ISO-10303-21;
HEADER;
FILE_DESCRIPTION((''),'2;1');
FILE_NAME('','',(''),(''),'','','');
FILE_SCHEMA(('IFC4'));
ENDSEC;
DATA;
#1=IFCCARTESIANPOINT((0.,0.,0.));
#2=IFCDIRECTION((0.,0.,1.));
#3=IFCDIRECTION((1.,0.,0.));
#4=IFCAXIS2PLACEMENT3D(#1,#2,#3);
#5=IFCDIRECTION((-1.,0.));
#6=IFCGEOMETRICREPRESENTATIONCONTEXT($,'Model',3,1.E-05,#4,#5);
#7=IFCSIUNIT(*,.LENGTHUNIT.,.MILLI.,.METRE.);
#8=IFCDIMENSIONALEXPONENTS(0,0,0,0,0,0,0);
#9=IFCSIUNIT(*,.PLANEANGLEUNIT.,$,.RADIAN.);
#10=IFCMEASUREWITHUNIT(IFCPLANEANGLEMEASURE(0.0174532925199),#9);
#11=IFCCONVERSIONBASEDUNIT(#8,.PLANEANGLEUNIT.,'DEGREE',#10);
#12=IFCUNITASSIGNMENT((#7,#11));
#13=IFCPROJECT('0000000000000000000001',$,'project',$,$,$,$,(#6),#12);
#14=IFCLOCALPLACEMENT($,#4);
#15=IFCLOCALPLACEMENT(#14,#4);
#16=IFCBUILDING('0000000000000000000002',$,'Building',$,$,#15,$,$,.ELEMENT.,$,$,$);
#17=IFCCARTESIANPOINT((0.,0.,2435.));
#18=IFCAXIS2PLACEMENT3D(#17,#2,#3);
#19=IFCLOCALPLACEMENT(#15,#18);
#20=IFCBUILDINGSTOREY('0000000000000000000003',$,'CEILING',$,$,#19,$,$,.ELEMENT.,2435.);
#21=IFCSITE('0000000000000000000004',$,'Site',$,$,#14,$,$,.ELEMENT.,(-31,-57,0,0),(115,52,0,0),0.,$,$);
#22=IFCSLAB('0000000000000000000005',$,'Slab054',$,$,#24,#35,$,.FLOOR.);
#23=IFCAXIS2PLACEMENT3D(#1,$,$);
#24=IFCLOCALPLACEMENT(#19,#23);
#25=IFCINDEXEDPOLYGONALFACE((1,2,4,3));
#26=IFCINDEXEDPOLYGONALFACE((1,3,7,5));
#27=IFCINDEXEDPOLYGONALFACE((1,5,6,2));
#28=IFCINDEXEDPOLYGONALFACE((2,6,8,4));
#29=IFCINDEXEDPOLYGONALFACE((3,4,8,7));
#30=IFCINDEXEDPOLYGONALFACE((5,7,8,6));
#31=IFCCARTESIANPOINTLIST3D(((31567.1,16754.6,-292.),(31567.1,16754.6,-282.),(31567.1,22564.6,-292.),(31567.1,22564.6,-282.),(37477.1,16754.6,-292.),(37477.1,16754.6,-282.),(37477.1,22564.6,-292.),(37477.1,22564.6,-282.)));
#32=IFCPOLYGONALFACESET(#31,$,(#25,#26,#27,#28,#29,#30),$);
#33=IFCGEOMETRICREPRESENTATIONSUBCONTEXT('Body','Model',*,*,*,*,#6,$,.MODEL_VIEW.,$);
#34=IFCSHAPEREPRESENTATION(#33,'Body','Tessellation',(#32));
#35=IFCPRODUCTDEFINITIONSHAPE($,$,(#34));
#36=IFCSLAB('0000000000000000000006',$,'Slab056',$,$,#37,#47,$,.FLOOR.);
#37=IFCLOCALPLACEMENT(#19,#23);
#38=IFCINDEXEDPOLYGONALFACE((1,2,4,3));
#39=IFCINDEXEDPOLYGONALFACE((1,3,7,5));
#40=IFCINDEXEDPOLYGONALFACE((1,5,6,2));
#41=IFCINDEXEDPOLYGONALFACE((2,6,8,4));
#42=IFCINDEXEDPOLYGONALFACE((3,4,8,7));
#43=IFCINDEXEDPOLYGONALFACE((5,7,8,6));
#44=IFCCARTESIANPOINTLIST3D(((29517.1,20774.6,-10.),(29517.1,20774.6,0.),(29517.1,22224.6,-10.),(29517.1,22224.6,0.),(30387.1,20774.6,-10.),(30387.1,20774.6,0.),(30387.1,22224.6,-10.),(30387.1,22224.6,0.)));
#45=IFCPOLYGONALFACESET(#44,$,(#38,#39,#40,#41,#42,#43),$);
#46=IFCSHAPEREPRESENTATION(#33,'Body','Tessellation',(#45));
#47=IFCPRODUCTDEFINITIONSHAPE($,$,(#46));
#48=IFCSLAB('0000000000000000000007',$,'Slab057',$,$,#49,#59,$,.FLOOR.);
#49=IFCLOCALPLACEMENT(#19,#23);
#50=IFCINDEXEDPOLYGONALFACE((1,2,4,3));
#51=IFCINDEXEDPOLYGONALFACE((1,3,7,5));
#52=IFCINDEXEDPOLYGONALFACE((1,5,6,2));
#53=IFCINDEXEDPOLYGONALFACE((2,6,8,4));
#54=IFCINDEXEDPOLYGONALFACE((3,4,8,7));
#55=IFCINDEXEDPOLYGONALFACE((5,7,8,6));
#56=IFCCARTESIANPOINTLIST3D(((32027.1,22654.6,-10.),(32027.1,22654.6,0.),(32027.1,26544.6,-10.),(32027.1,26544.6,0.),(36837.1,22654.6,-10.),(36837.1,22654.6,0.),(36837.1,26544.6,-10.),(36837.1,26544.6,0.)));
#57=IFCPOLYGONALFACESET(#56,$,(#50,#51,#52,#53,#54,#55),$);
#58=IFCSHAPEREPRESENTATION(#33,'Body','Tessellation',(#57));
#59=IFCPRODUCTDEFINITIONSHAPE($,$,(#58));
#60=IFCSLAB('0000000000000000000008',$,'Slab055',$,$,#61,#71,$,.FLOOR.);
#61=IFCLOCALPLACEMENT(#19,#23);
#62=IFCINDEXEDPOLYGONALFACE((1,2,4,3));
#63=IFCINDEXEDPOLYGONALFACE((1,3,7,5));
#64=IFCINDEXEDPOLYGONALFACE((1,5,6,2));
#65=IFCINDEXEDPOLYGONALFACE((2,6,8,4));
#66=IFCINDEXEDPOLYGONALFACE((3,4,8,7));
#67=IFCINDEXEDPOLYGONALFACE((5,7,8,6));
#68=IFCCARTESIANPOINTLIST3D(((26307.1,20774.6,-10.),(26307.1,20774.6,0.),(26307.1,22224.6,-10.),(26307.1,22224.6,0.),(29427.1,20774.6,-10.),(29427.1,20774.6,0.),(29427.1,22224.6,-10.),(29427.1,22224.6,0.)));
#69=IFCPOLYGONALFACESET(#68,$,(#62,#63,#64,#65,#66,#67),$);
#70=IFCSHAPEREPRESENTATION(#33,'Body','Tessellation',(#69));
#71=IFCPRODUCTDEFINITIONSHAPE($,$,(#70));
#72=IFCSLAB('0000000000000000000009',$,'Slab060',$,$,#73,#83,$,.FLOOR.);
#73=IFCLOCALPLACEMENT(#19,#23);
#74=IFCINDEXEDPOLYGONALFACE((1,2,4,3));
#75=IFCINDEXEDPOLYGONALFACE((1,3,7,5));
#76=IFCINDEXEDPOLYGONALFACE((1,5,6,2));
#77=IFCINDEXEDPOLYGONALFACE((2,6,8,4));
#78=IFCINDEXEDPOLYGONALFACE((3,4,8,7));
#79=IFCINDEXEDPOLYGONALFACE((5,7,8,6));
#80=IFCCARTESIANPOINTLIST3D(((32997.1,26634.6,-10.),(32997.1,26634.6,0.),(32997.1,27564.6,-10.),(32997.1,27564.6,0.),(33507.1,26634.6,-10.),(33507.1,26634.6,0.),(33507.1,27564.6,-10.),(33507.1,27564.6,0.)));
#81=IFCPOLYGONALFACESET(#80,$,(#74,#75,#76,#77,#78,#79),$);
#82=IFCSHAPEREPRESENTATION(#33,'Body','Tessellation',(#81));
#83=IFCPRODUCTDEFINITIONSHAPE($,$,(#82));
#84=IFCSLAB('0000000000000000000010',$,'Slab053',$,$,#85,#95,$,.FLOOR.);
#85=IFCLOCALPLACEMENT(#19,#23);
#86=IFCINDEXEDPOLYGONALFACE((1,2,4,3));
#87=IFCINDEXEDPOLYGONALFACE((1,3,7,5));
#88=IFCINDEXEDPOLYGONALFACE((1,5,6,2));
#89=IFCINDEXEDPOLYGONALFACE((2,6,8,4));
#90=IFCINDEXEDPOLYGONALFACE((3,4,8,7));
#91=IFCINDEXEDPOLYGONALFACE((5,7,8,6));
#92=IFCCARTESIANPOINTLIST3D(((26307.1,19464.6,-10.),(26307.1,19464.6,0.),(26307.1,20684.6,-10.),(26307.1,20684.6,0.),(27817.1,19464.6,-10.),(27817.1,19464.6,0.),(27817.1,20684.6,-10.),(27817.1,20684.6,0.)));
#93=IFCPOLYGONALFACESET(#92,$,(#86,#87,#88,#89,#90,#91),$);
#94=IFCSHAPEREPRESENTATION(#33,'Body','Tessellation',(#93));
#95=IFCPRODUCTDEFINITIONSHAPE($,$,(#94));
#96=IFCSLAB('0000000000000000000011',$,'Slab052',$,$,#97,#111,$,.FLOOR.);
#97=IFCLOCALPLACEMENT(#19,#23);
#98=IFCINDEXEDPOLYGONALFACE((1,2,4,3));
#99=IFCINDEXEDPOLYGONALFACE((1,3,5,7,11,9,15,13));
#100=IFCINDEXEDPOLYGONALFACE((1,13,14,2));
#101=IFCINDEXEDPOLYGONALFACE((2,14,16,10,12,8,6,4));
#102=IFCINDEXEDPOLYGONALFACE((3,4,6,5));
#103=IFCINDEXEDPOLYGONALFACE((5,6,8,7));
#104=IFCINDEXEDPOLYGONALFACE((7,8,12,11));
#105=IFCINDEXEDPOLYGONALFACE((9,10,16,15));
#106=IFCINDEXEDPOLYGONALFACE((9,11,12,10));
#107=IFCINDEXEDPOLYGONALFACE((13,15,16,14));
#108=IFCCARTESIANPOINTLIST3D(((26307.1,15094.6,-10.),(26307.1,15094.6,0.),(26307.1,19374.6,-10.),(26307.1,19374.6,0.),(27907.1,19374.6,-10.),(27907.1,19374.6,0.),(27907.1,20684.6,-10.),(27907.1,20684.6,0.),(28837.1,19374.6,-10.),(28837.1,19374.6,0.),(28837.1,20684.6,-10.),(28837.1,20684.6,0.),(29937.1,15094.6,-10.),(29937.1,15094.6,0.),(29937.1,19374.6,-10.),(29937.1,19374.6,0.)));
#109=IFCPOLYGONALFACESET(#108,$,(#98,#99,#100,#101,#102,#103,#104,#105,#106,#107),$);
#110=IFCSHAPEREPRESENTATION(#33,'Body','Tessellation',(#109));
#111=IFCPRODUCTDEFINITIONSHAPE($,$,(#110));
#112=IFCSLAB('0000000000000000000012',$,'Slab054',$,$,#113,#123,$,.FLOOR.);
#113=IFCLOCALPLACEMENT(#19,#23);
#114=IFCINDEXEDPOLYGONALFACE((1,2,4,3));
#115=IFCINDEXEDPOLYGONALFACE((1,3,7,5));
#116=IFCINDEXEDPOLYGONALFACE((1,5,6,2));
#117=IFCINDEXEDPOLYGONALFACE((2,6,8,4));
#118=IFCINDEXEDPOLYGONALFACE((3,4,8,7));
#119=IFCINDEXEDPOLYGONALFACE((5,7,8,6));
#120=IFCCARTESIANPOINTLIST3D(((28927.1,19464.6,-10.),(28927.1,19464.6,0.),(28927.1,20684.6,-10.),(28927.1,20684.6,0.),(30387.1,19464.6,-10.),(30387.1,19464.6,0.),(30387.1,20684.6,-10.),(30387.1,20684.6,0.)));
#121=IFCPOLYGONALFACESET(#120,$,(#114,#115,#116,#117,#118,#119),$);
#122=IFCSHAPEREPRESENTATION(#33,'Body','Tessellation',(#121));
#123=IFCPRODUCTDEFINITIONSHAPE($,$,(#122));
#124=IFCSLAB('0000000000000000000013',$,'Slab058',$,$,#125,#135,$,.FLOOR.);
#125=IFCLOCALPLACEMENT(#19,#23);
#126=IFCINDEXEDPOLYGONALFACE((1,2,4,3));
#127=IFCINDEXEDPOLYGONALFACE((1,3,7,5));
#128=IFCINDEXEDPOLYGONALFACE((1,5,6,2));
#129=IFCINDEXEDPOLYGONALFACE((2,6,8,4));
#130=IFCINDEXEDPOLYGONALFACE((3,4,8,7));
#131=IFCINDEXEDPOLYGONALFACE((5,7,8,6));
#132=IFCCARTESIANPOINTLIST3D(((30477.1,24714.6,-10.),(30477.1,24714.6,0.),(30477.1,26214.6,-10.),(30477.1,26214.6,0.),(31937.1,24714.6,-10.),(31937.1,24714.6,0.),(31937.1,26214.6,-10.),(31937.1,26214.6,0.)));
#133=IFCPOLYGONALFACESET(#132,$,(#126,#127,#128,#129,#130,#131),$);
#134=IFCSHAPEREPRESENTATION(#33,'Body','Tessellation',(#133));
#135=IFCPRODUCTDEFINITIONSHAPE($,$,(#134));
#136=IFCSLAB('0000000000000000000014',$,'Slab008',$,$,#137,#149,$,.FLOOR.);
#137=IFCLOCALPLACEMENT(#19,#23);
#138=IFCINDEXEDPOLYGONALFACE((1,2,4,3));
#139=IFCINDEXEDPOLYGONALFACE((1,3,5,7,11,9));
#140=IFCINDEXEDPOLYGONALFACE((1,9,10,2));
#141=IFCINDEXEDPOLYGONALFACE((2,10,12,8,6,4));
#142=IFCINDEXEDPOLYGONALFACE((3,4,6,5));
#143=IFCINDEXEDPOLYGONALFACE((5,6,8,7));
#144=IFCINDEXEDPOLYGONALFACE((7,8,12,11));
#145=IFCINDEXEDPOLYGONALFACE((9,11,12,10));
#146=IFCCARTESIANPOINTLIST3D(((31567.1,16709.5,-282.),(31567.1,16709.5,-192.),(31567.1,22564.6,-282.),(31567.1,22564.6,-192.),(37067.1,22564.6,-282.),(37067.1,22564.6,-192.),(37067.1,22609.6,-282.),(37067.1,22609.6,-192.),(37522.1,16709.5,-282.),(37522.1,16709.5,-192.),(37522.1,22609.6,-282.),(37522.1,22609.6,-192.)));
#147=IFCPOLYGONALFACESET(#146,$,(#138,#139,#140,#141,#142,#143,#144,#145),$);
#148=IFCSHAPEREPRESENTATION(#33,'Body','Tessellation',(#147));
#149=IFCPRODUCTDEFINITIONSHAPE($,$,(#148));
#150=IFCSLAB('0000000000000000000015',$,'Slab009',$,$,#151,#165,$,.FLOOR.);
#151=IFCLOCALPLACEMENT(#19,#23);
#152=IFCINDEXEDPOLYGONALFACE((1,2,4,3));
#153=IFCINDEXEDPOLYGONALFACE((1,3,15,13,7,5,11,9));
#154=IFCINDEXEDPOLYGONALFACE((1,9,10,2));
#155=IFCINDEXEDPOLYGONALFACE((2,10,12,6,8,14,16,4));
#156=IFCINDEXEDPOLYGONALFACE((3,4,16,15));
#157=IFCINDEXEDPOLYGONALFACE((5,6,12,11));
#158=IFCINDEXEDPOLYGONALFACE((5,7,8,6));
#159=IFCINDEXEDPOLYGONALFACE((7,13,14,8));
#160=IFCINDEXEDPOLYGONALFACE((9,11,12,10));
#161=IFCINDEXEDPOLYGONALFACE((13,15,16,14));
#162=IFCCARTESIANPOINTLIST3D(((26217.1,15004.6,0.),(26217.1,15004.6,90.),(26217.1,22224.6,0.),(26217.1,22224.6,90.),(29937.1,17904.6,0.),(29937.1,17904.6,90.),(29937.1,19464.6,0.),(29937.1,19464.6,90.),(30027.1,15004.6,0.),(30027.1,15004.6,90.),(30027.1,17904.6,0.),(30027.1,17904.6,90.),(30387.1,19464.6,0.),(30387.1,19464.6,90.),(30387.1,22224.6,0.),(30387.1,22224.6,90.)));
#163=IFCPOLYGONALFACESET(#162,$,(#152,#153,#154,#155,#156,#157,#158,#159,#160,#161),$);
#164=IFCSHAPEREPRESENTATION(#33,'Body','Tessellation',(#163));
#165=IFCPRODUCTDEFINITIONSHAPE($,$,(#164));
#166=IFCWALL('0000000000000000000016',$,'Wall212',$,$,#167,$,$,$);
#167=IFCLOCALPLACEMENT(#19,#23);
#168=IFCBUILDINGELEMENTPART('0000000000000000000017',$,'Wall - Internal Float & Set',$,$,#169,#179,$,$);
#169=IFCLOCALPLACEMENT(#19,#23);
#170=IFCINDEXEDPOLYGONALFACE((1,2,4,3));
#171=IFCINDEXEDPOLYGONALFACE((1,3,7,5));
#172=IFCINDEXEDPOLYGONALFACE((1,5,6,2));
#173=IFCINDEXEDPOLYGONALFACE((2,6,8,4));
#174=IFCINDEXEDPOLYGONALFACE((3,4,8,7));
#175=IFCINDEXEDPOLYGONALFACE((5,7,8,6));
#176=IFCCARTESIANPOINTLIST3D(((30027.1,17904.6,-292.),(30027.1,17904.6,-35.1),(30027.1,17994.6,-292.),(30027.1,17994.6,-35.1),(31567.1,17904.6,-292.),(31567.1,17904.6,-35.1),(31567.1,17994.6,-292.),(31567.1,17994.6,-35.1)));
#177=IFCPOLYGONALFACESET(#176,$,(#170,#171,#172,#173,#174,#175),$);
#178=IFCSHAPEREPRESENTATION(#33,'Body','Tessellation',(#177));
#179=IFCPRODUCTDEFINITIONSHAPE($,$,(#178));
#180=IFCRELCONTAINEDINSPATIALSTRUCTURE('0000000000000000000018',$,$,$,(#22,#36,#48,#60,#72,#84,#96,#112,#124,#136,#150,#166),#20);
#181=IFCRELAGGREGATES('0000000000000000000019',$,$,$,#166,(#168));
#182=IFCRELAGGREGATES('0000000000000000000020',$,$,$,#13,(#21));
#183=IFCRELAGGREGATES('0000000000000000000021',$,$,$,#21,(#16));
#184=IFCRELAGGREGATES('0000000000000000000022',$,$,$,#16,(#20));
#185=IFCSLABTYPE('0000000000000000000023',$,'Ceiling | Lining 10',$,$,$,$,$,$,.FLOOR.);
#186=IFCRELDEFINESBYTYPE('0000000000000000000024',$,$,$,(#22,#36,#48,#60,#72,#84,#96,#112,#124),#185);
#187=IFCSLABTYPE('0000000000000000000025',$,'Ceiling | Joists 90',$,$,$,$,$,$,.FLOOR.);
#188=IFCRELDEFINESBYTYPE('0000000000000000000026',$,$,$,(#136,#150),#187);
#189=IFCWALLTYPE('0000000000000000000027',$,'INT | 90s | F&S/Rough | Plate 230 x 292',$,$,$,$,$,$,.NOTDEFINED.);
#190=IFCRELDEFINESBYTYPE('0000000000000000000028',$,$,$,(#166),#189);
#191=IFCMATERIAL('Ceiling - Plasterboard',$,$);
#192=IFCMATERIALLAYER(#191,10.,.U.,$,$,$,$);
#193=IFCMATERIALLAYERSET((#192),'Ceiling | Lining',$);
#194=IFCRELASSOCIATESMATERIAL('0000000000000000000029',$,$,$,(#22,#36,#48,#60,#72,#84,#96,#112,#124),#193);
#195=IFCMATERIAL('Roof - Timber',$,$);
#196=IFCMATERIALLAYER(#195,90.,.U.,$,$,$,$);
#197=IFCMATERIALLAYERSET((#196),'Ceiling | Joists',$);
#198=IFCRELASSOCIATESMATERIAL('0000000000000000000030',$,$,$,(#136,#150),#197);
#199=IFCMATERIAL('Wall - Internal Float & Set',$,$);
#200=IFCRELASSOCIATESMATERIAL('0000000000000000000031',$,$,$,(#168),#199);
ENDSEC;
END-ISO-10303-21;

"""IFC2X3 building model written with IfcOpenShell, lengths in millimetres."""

from ifc_helpers import new_model, entity, si_unit, converted_unit, direction, frame, origin_with_axes, place, context, subcontext, project, spatial, polyline, outline, extrude, material, layer, layer_set, layer_usage, type_object, element, aggregate, save


model = new_model("IFC2X3")

# Units and contexts
model_context = context("Model", 3, precision=1e-05, world=origin_with_axes(), true_north=direction((-1.0, 0.0)))
body_context = subcontext(model_context, "Body", "Model", "MODEL_VIEW")
ifc_project = project(units=[si_unit("LENGTHUNIT", "METRE", prefix="MILLI"), converted_unit("PLANEANGLEUNIT", "DEGREE", entity("IfcPlaneAngleMeasure", 0.0174532925199), si_unit("PLANEANGLEUNIT", "RADIAN"), dimensions=[0, 0, 0, 0, 0, 0, 0])], contexts=[model_context])

# Site, building, storey
site_placement = place(None, origin_with_axes())
site = spatial("IfcSite", under=ifc_project, at=site_placement, Name="Site", CompositionType="ELEMENT", RefLatitude=(-31, -57, 0, 0), RefLongitude=(115, 52, 0, 0), RefElevation=0.0)
building_placement = place(site_placement, origin_with_axes())
building = spatial("IfcBuilding", under=site, at=building_placement, Name="Building", CompositionType="ELEMENT")
storey_placement = place(building_placement, frame((0.0, 0.0, 2435.0), z_axis=(0.0, 0.0, 1.0), x_axis=(1.0, 0.0, 0.0)))
storey = spatial("IfcBuildingStorey", under=building, at=storey_placement, Name="CEILING", CompositionType="ELEMENT", Elevation=2435.0)

# Slabs
ifc_material_1 = material(Name="Ceiling - Plasterboard")
ifc_layer_1 = layer(ifc_material_1, 10.0, ventilated="UNKNOWN")
ifc_layer_set_1 = layer_set([ifc_layer_1], Name="Ceiling | Lining")
ifc_layer_usage_1 = layer_usage(ifc_layer_set_1, "AXIS3", "NEGATIVE", 10.0)
slab_type_1 = type_object("IfcSlabType", Name="Ceiling | Lining 10", PredefinedType="FLOOR")
slab_1_placement = place(storey_placement, frame((31567.1, 22564.6, -282.0), z_axis=(0.0, 0.0, 1.0), x_axis=(1.0, 0.0, 0.0)))
element("IfcSlab", 1, at=slab_1_placement, inside=storey, type_object=slab_type_1, material=ifc_layer_usage_1, Name="Slab054", PredefinedType="FLOOR", context=body_context, shape_type="SweptSolid", body=[
    extrude(outline(polyline([(0.0, 0.0), (0.0, -5810.0), (5910.0, -5810.0), (5910.0, 0.0), (0.0, 0.0)])), frame((0.0, 0.0, -10.0), z_axis=(0.0, 0.0, 1.0), x_axis=(1.0, 0.0, 0.0)), (0.0, 0.0, 1.0), 10.0),
])
ifc_layer_usage_2 = layer_usage(ifc_layer_set_1, "AXIS3", "NEGATIVE", 10.0)
slab_2_placement = place(storey_placement, frame((29517.1, 22224.6, 0.0), z_axis=(0.0, 0.0, 1.0), x_axis=(1.0, 0.0, 0.0)))
element("IfcSlab", 2, at=slab_2_placement, inside=storey, type_object=slab_type_1, material=ifc_layer_usage_2, Name="Slab056", PredefinedType="FLOOR", context=body_context, shape_type="SweptSolid", body=[
    extrude(outline(polyline([(0.0, 0.0), (0.0, -1450.0), (870.0, -1450.0), (870.0, 0.0), (0.0, 0.0)])), frame((0.0, 0.0, -10.0), z_axis=(0.0, 0.0, 1.0), x_axis=(1.0, 0.0, 0.0)), (0.0, 0.0, 1.0), 10.0),
])
ifc_layer_usage_3 = layer_usage(ifc_layer_set_1, "AXIS3", "NEGATIVE", 10.0)
slab_3_placement = place(storey_placement, frame((32027.1, 22654.6, 0.0), z_axis=(0.0, 0.0, 1.0), x_axis=(1.0, 0.0, 0.0)))
element("IfcSlab", 3, at=slab_3_placement, inside=storey, type_object=slab_type_1, material=ifc_layer_usage_3, Name="Slab057", PredefinedType="FLOOR", context=body_context, shape_type="SweptSolid", body=[
    extrude(outline(polyline([(0.0, 0.0), (4810.0, 0.0), (4810.0, 3890.0), (0.0, 3890.0), (0.0, 0.0)])), frame((0.0, 0.0, -10.0), z_axis=(0.0, 0.0, 1.0), x_axis=(1.0, 0.0, 0.0)), (0.0, 0.0, 1.0), 10.0),
])
ifc_layer_usage_4 = layer_usage(ifc_layer_set_1, "AXIS3", "NEGATIVE", 10.0)
slab_4_placement = place(storey_placement, frame((26307.1, 22224.6, 0.0), z_axis=(0.0, 0.0, 1.0), x_axis=(1.0, 0.0, 0.0)))
element("IfcSlab", 4, at=slab_4_placement, inside=storey, type_object=slab_type_1, material=ifc_layer_usage_4, Name="Slab055", PredefinedType="FLOOR", context=body_context, shape_type="SweptSolid", body=[
    extrude(outline(polyline([(0.0, 0.0), (0.0, -1450.0), (3120.0, -1450.0), (3120.0, 0.0), (0.0, 0.0)])), frame((0.0, 0.0, -10.0), z_axis=(0.0, 0.0, 1.0), x_axis=(1.0, 0.0, 0.0)), (0.0, 0.0, 1.0), 10.0),
])
ifc_layer_usage_5 = layer_usage(ifc_layer_set_1, "AXIS3", "NEGATIVE", 10.0)
slab_5_placement = place(storey_placement, frame((32997.1, 27564.6, 0.0), z_axis=(0.0, 0.0, 1.0), x_axis=(1.0, 0.0, 0.0)))
element("IfcSlab", 5, at=slab_5_placement, inside=storey, type_object=slab_type_1, material=ifc_layer_usage_5, Name="Slab060", PredefinedType="FLOOR", context=body_context, shape_type="SweptSolid", body=[
    extrude(outline(polyline([(0.0, 0.0), (0.0, -930.0), (510.0, -930.0), (510.0, 0.0), (0.0, 0.0)])), frame((0.0, 0.0, -10.0), z_axis=(0.0, 0.0, 1.0), x_axis=(1.0, 0.0, 0.0)), (0.0, 0.0, 1.0), 10.0),
])
ifc_layer_usage_6 = layer_usage(ifc_layer_set_1, "AXIS3", "NEGATIVE", 10.0)
slab_6_placement = place(storey_placement, frame((26307.1, 20684.6, 0.0), z_axis=(0.0, 0.0, 1.0), x_axis=(1.0, 0.0, 0.0)))
element("IfcSlab", 6, at=slab_6_placement, inside=storey, type_object=slab_type_1, material=ifc_layer_usage_6, Name="Slab053", PredefinedType="FLOOR", context=body_context, shape_type="SweptSolid", body=[
    extrude(outline(polyline([(0.0, 0.0), (0.0, -1220.0), (1510.0, -1220.0), (1510.0, 0.0), (0.0, 0.0)])), frame((0.0, 0.0, -10.0), z_axis=(0.0, 0.0, 1.0), x_axis=(1.0, 0.0, 0.0)), (0.0, 0.0, 1.0), 10.0),
])
ifc_layer_usage_7 = layer_usage(ifc_layer_set_1, "AXIS3", "NEGATIVE", 10.0)
slab_7_placement = place(storey_placement, frame((26307.1, 19374.6, 0.0), z_axis=(0.0, 0.0, 1.0), x_axis=(1.0, 0.0, 0.0)))
element("IfcSlab", 7, at=slab_7_placement, inside=storey, type_object=slab_type_1, material=ifc_layer_usage_7, Name="Slab052", PredefinedType="FLOOR", context=body_context, shape_type="SweptSolid", body=[
    extrude(outline(polyline([(0.0, 0.0), (0.0, -4280.0), (3630.0, -4280.0), (3630.0, 0.0), (2530.0, 0.0), (2530.0, 1310.0), (1600.0, 1310.0), (1600.0, 0.0), (0.0, 0.0)])), frame((0.0, 0.0, -10.0), z_axis=(0.0, 0.0, 1.0), x_axis=(1.0, 0.0, 0.0)), (0.0, 0.0, 1.0), 10.0),
])
ifc_layer_usage_8 = layer_usage(ifc_layer_set_1, "AXIS3", "NEGATIVE", 10.0)
slab_8_placement = place(storey_placement, frame((28927.1, 19464.6, 0.0), z_axis=(0.0, 0.0, 1.0), x_axis=(1.0, 0.0, 0.0)))
element("IfcSlab", 8, at=slab_8_placement, inside=storey, type_object=slab_type_1, material=ifc_layer_usage_8, Name="Slab054", PredefinedType="FLOOR", context=body_context, shape_type="SweptSolid", body=[
    extrude(outline(polyline([(0.0, 0.0), (1460.0, 0.0), (1460.0, 1220.0), (0.0, 1220.0), (0.0, 0.0)])), frame((0.0, 0.0, -10.0), z_axis=(0.0, 0.0, 1.0), x_axis=(1.0, 0.0, 0.0)), (0.0, 0.0, 1.0), 10.0),
])
ifc_layer_usage_9 = layer_usage(ifc_layer_set_1, "AXIS3", "NEGATIVE", 10.0)
slab_9_placement = place(storey_placement, frame((30477.1, 26214.6, 0.0), z_axis=(0.0, 0.0, 1.0), x_axis=(1.0, 0.0, 0.0)))
element("IfcSlab", 9, at=slab_9_placement, inside=storey, type_object=slab_type_1, material=ifc_layer_usage_9, Name="Slab058", PredefinedType="FLOOR", context=body_context, shape_type="SweptSolid", body=[
    extrude(outline(polyline([(0.0, 0.0), (0.0, -1500.0), (1460.0, -1500.0), (1460.0, 0.0), (0.0, 0.0)])), frame((0.0, 0.0, -10.0), z_axis=(0.0, 0.0, 1.0), x_axis=(1.0, 0.0, 0.0)), (0.0, 0.0, 1.0), 10.0),
])
ifc_material_2 = material(Name="Roof - Timber")
ifc_layer_2 = layer(ifc_material_2, 90.0, ventilated="UNKNOWN")
ifc_layer_set_2 = layer_set([ifc_layer_2], Name="Ceiling | Joists")
ifc_layer_usage_10 = layer_usage(ifc_layer_set_2, "AXIS3", "NEGATIVE", 90.0)
slab_type_2 = type_object("IfcSlabType", Name="Ceiling | Joists 90", PredefinedType="FLOOR")
slab_10_placement = place(storey_placement, frame((37067.1, 22609.6, -282.0), z_axis=(0.0, 0.0, 1.0), x_axis=(1.0, 0.0, 0.0)))
element("IfcSlab", 10, at=slab_10_placement, inside=storey, type_object=slab_type_2, material=ifc_layer_usage_10, Name="Slab008", PredefinedType="FLOOR", context=body_context, shape_type="SweptSolid", body=[
    extrude(outline(polyline([(0.0, 0.0), (0.0, -45.0), (-5500.0, -45.0), (-5500.0, -5900.1), (455.0, -5900.1), (455.0, 0.0), (0.0, 0.0)])), origin_with_axes(), (0.0, 0.0, 1.0), 90.0),
])
ifc_layer_usage_11 = layer_usage(ifc_layer_set_2, "AXIS3", "NEGATIVE", 90.0)
slab_11_placement = place(storey_placement, frame((26217.1, 22224.6, 0.0), z_axis=(0.0, 0.0, 1.0), x_axis=(1.0, 0.0, 0.0)))
element("IfcSlab", 11, at=slab_11_placement, inside=storey, type_object=slab_type_2, material=ifc_layer_usage_11, Name="Slab009", PredefinedType="FLOOR", context=body_context, shape_type="SweptSolid", body=[
    extrude(outline(polyline([(0.0, 0.0), (0.0, -7220.0), (3810.0, -7220.0), (3810.0, -4320.0), (3720.0, -4320.0), (3720.0, -2760.0), (4170.0, -2760.0), (4170.0, 0.0), (0.0, 0.0)])), origin_with_axes(), (0.0, 0.0, 1.0), 90.0),
])

# Wall, building element part
wall_type = type_object("IfcWallType", Name="INT | 90s | F&S/Rough | Plate 230 x 292", PredefinedType="NOTDEFINED")
wall_1_placement = place(storey_placement, frame((31567.1, 17904.6, -292.0), z_axis=(0.0, 0.0, 1.0), x_axis=(-1.0, 0.0, 0.0)))
wall_1 = element("IfcWall", 12, at=wall_1_placement, inside=storey, type_object=wall_type, Name="Wall212")
ifc_material_3 = material(Name="Wall - Internal Float & Set")
building_element_part_1_placement = place(wall_1_placement, origin_with_axes())
building_element_part_1 = element("IfcBuildingElementPart", 13, at=building_element_part_1_placement, material=ifc_material_3, Name="Wall - Internal Float & Set", context=body_context, shape_type="SweptSolid", body=[
    extrude(outline(polyline([(-90.0, 256.9), (-90.0, 0.0), (0.0, 0.0), (0.0, 256.9), (-90.0, 256.9)])), frame((0.0, 0.0, 0.0), z_axis=(1.0, 0.0, 0.0), x_axis=(0.0, 1.0, 0.0)), (0.0, 0.0, 1.0), 1540.0),
])
aggregate(wall_1, [building_element_part_1])

save(model, "model.ifc")
